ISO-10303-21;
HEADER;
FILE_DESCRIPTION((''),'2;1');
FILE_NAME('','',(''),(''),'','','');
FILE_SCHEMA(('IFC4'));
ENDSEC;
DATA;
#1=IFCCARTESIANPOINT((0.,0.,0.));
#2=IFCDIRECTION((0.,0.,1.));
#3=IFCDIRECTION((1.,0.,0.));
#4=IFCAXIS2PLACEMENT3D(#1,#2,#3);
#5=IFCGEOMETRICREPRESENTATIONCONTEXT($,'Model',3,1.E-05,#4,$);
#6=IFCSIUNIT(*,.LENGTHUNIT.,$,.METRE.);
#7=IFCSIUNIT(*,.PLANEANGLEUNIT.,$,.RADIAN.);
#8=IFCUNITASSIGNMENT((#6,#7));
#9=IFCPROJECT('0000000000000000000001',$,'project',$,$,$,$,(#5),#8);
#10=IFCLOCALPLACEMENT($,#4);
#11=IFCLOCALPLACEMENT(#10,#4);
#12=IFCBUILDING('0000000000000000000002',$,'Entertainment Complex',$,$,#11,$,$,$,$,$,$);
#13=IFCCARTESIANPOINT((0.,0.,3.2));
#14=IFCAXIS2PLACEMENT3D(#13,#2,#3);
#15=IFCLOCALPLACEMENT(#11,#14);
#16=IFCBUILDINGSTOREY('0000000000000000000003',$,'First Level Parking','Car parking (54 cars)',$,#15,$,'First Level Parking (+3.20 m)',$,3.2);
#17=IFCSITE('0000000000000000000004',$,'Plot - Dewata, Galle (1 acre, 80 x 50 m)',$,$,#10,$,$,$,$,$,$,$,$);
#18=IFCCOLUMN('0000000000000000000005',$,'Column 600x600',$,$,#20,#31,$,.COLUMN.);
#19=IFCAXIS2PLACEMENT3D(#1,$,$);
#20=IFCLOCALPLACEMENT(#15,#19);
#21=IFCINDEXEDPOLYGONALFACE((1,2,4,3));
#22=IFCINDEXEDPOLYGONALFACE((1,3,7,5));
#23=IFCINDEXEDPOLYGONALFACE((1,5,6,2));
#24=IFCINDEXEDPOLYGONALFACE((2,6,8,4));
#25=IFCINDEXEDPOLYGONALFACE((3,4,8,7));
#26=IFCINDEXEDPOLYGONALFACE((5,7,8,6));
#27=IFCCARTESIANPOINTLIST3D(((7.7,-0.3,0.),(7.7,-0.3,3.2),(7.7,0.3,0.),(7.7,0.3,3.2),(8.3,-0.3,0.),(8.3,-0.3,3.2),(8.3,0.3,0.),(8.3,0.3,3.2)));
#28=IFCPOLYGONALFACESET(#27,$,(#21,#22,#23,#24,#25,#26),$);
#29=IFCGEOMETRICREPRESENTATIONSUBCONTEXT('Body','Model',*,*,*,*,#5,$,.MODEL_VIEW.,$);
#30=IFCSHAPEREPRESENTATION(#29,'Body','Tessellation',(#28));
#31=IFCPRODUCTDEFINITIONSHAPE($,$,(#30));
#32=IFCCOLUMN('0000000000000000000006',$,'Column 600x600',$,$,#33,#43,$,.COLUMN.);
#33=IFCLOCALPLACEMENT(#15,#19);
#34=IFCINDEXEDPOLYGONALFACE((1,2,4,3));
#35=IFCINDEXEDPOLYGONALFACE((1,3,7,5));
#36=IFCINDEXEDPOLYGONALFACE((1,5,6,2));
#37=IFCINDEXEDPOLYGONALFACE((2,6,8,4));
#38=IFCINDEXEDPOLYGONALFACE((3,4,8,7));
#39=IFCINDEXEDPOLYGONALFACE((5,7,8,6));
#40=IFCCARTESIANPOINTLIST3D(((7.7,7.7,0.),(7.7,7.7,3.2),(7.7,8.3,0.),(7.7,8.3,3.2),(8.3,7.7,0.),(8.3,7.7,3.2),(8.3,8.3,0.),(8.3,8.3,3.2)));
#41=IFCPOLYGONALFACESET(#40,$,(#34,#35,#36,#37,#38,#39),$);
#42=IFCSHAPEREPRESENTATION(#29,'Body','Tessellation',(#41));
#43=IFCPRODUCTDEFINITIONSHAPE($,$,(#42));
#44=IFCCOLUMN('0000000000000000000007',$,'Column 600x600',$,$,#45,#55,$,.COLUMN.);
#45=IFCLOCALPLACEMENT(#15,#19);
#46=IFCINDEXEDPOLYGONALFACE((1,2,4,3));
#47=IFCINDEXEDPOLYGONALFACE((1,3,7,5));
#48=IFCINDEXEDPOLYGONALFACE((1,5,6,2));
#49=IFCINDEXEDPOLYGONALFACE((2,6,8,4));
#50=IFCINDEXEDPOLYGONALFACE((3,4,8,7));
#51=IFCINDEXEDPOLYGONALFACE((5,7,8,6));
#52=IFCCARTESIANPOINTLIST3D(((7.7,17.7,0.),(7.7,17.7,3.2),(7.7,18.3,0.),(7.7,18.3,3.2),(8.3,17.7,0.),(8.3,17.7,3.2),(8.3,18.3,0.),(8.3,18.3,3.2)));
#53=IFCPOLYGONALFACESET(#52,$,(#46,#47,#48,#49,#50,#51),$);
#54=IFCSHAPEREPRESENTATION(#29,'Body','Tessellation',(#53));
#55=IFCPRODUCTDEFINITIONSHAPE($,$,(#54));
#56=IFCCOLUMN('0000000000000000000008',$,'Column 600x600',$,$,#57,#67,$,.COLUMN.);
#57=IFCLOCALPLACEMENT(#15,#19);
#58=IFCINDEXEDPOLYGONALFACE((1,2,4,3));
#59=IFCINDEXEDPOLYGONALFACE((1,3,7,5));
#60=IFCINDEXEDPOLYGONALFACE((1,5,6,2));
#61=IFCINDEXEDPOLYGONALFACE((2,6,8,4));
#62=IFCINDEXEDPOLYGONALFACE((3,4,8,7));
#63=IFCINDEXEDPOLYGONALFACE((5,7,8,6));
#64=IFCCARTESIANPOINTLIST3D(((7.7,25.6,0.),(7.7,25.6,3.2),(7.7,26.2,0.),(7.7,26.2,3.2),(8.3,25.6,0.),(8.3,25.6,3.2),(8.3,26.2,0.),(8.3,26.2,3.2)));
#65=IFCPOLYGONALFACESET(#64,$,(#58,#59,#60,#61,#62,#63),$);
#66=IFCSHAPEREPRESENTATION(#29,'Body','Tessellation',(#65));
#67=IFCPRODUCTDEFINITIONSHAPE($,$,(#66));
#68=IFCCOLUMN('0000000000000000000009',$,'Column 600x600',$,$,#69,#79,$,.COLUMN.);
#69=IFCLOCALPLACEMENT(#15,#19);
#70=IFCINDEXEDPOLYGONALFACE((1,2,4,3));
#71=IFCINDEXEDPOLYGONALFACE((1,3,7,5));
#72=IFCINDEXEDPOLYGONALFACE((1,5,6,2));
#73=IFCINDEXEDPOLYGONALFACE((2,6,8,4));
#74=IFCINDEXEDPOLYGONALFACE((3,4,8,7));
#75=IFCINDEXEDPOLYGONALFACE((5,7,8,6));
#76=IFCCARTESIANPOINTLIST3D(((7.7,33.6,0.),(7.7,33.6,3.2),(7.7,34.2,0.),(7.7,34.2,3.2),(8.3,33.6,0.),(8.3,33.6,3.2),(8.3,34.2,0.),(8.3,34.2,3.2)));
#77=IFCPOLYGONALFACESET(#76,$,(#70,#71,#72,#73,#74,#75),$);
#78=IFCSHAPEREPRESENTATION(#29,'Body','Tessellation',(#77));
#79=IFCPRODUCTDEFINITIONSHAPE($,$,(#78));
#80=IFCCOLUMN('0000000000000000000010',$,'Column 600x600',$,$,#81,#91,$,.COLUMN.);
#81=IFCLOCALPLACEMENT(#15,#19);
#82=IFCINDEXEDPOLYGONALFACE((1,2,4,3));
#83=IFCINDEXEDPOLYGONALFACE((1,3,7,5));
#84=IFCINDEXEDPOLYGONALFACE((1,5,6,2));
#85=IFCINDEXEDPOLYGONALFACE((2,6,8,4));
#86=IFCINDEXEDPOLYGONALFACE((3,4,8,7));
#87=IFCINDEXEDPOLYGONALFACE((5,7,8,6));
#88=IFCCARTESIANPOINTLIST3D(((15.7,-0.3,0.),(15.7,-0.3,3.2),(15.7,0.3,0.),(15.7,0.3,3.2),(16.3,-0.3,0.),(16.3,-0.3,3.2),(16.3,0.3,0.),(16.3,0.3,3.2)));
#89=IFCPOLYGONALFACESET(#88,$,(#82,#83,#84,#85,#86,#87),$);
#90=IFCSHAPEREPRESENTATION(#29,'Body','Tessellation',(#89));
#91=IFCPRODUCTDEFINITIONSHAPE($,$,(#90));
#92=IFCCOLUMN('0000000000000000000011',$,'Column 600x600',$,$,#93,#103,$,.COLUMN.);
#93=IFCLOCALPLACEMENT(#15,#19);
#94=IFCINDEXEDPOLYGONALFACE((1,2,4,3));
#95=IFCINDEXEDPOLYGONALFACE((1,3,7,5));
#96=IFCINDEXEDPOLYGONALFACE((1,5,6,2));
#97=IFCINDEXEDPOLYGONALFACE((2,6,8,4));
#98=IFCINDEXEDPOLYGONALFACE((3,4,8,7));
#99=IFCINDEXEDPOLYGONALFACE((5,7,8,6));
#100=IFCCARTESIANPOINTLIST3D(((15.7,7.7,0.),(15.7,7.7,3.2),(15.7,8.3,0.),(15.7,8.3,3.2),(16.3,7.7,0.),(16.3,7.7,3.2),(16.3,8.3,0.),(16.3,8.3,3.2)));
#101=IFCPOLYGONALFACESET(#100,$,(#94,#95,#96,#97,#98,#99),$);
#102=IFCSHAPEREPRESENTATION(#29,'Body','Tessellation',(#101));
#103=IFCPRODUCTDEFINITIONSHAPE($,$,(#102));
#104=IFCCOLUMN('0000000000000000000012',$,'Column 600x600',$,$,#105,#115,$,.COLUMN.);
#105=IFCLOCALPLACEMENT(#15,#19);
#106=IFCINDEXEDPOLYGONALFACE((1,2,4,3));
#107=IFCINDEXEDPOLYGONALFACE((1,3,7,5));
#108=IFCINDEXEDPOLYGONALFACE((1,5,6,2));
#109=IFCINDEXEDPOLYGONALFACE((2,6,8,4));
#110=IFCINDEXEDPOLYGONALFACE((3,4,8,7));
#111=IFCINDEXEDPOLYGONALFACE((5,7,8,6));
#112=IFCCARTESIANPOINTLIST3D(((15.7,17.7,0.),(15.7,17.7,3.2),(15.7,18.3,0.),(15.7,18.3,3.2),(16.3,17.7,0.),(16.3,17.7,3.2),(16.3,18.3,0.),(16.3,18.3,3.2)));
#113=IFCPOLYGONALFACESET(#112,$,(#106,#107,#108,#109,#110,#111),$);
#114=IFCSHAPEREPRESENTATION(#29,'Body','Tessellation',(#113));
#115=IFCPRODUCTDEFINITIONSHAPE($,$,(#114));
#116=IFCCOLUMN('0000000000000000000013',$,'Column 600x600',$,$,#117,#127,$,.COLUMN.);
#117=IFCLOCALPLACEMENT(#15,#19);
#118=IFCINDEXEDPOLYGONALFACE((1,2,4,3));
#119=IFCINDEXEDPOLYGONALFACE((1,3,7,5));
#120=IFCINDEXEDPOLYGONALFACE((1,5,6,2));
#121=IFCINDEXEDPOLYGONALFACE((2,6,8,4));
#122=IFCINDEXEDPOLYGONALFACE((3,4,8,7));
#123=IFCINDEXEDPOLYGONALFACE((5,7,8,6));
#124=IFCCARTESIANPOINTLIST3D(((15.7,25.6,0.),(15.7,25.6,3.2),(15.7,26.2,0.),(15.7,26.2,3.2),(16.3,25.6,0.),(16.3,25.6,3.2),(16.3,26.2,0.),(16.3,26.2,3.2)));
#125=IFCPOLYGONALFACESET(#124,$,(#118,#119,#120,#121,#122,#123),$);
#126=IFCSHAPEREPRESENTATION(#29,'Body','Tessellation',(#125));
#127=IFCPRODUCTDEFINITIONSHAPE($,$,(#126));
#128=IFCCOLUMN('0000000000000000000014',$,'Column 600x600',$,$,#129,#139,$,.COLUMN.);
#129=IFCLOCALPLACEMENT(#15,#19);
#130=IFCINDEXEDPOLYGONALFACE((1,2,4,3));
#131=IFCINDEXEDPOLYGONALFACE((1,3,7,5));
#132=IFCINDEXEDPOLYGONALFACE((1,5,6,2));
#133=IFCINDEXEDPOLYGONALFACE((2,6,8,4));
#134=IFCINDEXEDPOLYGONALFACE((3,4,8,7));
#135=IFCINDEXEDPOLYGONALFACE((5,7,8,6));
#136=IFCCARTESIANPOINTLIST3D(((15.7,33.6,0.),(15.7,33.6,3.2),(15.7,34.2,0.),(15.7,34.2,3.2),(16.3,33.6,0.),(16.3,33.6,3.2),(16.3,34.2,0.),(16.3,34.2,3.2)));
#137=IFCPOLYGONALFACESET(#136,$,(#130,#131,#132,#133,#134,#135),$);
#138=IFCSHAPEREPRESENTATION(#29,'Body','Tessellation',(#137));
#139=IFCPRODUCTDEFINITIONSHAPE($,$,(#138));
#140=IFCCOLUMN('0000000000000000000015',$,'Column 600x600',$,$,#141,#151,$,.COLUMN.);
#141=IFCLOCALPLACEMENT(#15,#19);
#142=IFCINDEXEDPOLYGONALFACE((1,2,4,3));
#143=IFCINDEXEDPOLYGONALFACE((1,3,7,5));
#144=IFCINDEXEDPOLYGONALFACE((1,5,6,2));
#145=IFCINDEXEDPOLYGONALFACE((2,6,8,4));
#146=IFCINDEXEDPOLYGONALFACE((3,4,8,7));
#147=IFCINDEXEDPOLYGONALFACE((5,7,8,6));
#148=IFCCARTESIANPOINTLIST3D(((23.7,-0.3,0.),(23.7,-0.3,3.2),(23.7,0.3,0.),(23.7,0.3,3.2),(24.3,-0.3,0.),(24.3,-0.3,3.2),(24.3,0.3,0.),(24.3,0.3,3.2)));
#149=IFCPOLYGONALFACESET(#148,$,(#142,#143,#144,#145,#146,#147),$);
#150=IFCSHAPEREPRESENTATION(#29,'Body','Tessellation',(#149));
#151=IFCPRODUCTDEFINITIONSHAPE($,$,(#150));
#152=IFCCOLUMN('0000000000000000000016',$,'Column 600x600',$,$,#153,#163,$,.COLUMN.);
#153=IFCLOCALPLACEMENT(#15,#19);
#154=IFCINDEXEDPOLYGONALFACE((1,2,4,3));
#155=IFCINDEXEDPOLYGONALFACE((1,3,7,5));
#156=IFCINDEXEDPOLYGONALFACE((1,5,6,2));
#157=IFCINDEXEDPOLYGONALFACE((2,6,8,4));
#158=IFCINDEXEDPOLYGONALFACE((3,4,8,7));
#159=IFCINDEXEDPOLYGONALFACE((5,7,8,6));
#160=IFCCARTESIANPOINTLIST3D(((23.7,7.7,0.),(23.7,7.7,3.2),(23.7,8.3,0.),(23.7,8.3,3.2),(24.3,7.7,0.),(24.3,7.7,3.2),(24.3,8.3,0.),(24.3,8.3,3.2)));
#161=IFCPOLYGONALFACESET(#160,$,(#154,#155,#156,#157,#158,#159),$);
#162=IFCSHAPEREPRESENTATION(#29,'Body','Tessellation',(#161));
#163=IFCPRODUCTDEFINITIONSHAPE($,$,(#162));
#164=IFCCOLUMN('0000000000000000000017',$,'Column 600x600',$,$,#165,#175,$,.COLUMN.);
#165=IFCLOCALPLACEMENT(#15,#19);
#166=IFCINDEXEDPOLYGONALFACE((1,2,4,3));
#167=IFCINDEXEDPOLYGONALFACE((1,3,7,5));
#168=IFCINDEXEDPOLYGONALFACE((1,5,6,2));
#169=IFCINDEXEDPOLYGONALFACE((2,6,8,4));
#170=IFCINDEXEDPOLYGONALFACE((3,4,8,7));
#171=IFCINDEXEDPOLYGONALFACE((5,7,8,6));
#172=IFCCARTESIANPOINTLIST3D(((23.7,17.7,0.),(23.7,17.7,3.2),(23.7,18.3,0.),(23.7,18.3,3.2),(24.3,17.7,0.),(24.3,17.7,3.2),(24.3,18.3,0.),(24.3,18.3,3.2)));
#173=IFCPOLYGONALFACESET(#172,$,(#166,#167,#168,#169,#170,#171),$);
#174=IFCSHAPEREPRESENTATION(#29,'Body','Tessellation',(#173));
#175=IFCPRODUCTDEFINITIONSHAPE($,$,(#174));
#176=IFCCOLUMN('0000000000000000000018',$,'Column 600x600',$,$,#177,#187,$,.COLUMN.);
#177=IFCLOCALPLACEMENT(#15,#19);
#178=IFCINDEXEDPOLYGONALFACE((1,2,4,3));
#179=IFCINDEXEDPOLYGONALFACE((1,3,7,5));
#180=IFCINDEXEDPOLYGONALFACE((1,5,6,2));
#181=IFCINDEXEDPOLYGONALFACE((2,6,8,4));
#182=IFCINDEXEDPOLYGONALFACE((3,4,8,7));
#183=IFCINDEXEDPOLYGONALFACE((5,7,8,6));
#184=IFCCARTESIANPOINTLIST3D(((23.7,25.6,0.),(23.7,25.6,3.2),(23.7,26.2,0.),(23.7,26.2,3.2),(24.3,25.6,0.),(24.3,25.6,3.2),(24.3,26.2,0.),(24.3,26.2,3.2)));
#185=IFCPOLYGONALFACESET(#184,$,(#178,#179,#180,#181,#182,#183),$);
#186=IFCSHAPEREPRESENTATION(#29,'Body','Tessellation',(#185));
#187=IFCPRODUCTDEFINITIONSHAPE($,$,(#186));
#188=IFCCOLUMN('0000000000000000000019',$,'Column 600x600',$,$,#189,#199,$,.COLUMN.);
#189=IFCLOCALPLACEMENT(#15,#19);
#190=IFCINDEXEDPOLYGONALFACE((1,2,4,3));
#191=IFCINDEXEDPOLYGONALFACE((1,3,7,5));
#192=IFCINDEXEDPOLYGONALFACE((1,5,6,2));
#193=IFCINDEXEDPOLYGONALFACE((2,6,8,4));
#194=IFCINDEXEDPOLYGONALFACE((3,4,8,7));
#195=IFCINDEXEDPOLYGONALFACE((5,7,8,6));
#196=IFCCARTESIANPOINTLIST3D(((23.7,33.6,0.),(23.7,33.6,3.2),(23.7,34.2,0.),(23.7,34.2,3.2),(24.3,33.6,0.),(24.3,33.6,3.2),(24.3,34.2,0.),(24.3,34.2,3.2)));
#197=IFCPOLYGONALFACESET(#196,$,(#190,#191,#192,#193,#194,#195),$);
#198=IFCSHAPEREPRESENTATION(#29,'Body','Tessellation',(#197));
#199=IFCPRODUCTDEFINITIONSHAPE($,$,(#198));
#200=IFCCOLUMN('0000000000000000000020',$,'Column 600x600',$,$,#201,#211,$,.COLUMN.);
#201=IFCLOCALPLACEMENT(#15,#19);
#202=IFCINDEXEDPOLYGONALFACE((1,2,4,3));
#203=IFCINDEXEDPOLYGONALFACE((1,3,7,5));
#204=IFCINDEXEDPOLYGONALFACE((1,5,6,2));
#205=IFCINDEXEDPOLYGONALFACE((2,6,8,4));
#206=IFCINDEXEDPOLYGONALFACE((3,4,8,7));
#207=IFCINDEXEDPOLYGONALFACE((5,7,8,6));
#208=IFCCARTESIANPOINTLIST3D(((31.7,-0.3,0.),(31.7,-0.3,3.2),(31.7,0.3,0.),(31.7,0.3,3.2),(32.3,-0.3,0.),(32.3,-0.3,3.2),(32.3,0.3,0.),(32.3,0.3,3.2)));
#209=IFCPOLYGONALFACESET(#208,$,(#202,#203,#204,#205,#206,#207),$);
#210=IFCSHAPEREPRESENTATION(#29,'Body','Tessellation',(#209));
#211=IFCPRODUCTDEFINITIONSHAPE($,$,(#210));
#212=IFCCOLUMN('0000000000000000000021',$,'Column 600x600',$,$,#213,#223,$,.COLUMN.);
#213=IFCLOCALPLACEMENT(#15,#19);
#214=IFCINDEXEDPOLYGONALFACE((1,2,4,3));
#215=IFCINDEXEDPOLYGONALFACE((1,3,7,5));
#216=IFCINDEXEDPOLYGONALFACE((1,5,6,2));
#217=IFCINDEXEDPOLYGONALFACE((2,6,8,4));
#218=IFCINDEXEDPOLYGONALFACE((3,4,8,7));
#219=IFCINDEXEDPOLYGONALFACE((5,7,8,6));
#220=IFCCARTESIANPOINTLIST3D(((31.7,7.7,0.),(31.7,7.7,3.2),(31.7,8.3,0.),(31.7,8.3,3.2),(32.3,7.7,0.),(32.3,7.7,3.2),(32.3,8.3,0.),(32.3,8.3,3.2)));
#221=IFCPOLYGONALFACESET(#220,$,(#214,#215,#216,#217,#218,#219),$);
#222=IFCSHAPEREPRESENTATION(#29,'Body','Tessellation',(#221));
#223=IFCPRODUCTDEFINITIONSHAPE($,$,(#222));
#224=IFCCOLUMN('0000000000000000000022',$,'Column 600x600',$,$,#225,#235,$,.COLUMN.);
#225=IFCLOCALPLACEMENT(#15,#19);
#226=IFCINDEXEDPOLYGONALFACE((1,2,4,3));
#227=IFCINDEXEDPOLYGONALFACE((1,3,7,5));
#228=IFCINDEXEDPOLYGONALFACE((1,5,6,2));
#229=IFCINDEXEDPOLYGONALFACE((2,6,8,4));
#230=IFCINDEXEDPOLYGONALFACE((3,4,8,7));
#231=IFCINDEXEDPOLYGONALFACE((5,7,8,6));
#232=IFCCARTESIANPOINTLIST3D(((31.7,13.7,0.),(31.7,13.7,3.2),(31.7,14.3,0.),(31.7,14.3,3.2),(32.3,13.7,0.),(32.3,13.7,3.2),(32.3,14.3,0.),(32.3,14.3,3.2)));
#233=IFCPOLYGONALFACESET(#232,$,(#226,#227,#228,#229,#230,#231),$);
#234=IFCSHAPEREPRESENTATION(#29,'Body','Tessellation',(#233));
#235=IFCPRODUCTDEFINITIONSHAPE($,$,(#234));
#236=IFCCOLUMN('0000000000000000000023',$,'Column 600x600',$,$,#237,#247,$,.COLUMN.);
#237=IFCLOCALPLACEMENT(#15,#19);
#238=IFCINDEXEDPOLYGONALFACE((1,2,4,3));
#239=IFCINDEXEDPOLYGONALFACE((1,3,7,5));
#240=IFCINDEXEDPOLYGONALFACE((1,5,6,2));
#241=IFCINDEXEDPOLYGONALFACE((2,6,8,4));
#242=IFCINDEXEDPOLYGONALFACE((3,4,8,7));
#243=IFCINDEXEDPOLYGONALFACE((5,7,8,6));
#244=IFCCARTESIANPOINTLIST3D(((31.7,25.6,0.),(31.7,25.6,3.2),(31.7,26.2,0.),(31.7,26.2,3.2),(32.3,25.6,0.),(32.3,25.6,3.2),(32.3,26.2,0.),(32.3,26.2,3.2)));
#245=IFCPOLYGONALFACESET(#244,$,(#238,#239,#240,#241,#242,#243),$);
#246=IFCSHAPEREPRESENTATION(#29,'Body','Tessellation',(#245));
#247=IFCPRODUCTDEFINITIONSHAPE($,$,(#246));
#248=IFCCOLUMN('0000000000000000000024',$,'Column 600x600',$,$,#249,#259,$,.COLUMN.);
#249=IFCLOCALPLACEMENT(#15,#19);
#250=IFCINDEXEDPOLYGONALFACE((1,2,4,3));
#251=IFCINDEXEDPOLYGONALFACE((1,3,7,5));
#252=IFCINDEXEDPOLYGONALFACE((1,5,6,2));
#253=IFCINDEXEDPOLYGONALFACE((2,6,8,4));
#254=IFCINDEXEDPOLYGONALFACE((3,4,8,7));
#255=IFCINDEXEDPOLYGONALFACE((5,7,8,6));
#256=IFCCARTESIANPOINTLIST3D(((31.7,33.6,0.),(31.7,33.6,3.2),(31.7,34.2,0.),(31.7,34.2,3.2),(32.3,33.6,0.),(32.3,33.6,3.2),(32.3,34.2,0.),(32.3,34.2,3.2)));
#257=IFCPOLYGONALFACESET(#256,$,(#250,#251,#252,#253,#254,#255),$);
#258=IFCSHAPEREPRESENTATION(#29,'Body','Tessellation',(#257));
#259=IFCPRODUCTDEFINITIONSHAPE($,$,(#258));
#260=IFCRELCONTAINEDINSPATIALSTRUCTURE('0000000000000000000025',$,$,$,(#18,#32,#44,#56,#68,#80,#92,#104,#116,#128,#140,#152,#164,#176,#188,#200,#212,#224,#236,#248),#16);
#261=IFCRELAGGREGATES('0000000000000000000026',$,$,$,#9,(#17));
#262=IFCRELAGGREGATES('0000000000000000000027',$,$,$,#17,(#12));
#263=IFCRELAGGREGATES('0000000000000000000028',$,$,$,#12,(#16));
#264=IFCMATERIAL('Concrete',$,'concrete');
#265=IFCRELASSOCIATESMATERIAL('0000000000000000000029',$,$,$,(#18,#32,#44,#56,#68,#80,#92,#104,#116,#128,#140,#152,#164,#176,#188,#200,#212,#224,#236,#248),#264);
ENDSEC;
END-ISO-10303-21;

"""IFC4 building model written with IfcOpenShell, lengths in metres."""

from ifc_helpers import new_model, si_unit, frame, origin_with_axes, place, context, subcontext, project, spatial, polyline, outline, extrude, material, element, save


model = new_model("IFC4")

# Units and contexts
model_context = context("Model", 3, precision=1e-05, world=origin_with_axes())
body_context = subcontext(model_context, "Body", "Model", "MODEL_VIEW")
ifc_project = project(units=[si_unit("LENGTHUNIT", "METRE"), si_unit("PLANEANGLEUNIT", "RADIAN")], contexts=[model_context])

# Site, building, storey
site_placement = place(None, origin_with_axes())
site = spatial("IfcSite", under=ifc_project, at=site_placement, Name="Plot - Dewata, Galle (1 acre, 80 x 50 m)")
building_placement = place(site_placement, origin_with_axes())
building = spatial("IfcBuilding", under=site, at=building_placement, Name="Entertainment Complex")
storey_placement = place(building_placement, frame((0.0, 0.0, 3.2), z_axis=(0.0, 0.0, 1.0), x_axis=(1.0, 0.0, 0.0)))
storey = spatial("IfcBuildingStorey", under=building, at=storey_placement, Name="First Level Parking", Description="Car parking (54 cars)", LongName="First Level Parking (+3.20 m)", Elevation=3.2)

# Columns
ifc_material_1 = material(Name="Concrete", Category="concrete")
for number, where, z_axis, x_axis, name in (
    (1, (8.0, 0.0, 0.0), (0.0, 0.0, 1.0), (1.0, 0.0, 0.0), "Column 600x600"),
    (2, (8.0, 8.0, 0.0), (0.0, 0.0, 1.0), (1.0, 0.0, 0.0), "Column 600x600"),
    (3, (8.0, 18.0, 0.0), (0.0, 0.0, 1.0), (1.0, 0.0, 0.0), "Column 600x600"),
    (4, (8.0, 25.9, 0.0), (0.0, 0.0, 1.0), (1.0, 0.0, 0.0), "Column 600x600"),
    (5, (8.0, 33.9, 0.0), (0.0, 0.0, 1.0), (1.0, 0.0, 0.0), "Column 600x600"),
    (6, (16.0, 0.0, 0.0), (0.0, 0.0, 1.0), (1.0, 0.0, 0.0), "Column 600x600"),
    (7, (16.0, 8.0, 0.0), (0.0, 0.0, 1.0), (1.0, 0.0, 0.0), "Column 600x600"),
    (8, (16.0, 18.0, 0.0), (0.0, 0.0, 1.0), (1.0, 0.0, 0.0), "Column 600x600"),
    (9, (16.0, 25.9, 0.0), (0.0, 0.0, 1.0), (1.0, 0.0, 0.0), "Column 600x600"),
    (10, (16.0, 33.9, 0.0), (0.0, 0.0, 1.0), (1.0, 0.0, 0.0), "Column 600x600"),
    (11, (24.0, 0.0, 0.0), (0.0, 0.0, 1.0), (1.0, 0.0, 0.0), "Column 600x600"),
    (12, (24.0, 8.0, 0.0), (0.0, 0.0, 1.0), (1.0, 0.0, 0.0), "Column 600x600"),
    (13, (24.0, 18.0, 0.0), (0.0, 0.0, 1.0), (1.0, 0.0, 0.0), "Column 600x600"),
    (14, (24.0, 25.9, 0.0), (0.0, 0.0, 1.0), (1.0, 0.0, 0.0), "Column 600x600"),
    (15, (24.0, 33.9, 0.0), (0.0, 0.0, 1.0), (1.0, 0.0, 0.0), "Column 600x600"),
    (16, (32.0, 0.0, 0.0), (0.0, 0.0, 1.0), (1.0, 0.0, 0.0), "Column 600x600"),
    (17, (32.0, 8.0, 0.0), (0.0, 0.0, 1.0), (1.0, 0.0, 0.0), "Column 600x600"),
    (18, (32.0, 14.0, 0.0), (0.0, 0.0, 1.0), (1.0, 0.0, 0.0), "Column 600x600"),
    (19, (32.0, 25.9, 0.0), (0.0, 0.0, 1.0), (1.0, 0.0, 0.0), "Column 600x600"),
    (20, (32.0, 33.9, 0.0), (0.0, 0.0, 1.0), (1.0, 0.0, 0.0), "Column 600x600"),
):
    element("IfcColumn", number, at=place(storey_placement, frame(where, z_axis=z_axis, x_axis=x_axis)), inside=storey, material=ifc_material_1, Name=name, PredefinedType="COLUMN", context=body_context, shape_type="SweptSolid", body=[
        extrude(outline(polyline([(-0.3, -0.3), (0.3, -0.3), (0.3, 0.3), (-0.3, 0.3), (-0.3, -0.3)])), origin_with_axes(), (0.0, 0.0, 1.0), 3.2),
    ])

save(model, "model.ifc")
